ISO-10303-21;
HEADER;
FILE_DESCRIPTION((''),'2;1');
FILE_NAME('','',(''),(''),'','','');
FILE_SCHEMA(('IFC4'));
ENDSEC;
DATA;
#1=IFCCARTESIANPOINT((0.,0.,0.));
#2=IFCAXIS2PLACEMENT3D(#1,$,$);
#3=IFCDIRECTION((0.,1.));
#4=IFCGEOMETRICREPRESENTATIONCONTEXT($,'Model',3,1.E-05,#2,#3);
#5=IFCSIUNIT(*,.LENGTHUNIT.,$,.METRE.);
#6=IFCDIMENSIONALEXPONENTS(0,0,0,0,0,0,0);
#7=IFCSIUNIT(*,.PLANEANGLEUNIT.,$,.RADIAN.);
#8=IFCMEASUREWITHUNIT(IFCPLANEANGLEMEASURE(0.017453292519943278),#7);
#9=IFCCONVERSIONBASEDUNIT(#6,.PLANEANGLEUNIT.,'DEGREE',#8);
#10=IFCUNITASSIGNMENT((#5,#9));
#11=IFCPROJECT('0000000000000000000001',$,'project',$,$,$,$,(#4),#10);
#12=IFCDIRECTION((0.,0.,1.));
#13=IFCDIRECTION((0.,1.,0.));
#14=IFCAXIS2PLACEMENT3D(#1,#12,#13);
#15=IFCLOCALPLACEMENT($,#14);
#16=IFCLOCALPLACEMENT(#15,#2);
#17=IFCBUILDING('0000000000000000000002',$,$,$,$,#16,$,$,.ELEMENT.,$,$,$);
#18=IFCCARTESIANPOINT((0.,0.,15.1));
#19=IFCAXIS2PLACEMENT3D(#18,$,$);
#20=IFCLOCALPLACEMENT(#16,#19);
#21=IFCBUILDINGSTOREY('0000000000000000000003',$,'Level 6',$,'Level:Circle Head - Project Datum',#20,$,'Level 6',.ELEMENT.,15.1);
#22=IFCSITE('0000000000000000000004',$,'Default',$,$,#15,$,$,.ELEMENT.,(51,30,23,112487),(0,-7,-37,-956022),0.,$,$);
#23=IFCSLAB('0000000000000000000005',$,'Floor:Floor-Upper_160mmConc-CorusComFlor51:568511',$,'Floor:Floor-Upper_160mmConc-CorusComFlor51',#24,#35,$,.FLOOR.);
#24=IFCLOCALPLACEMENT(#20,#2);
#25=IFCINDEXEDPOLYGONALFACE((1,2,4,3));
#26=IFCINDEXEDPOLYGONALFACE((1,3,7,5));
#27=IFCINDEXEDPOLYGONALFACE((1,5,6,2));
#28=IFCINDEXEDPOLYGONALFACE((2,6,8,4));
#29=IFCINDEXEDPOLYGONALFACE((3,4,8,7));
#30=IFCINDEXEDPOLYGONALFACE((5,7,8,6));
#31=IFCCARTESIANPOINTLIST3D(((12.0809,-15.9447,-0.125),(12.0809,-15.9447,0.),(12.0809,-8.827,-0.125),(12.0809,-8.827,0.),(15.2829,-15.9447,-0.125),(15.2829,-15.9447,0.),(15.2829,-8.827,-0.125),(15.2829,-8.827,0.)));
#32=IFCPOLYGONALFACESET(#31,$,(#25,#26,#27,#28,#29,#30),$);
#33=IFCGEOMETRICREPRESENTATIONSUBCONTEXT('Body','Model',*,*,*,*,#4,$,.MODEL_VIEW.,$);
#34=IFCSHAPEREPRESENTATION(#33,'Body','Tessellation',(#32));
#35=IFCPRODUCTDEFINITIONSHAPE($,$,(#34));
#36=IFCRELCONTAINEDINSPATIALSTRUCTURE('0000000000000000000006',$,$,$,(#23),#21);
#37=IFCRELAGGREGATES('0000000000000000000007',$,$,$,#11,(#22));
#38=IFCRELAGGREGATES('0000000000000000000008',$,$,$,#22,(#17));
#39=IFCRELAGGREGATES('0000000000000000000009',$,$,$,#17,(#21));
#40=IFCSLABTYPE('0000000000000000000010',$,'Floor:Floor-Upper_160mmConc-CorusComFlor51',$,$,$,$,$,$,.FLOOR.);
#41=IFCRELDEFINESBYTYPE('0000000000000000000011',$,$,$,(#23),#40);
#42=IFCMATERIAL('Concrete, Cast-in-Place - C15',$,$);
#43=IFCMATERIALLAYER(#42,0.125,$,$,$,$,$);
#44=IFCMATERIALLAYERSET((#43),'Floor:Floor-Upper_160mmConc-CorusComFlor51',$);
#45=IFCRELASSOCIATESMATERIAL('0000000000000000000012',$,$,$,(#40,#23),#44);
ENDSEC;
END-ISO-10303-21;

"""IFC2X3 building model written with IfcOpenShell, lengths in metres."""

from ifc_helpers import new_model, entity, si_unit, converted_unit, direction, frame, frame_2d, origin, place, context, subcontext, project, spatial, rectangle, extrude, material, layer, layer_set, layer_usage, type_object, element, save


model = new_model("IFC2X3")

# Units and contexts
model_context = context("Model", 3, precision=1e-05, world=origin(), true_north=direction((0.0, 1.0)))
body_context = subcontext(model_context, "Body", "Model", "MODEL_VIEW")
ifc_project = project(units=[si_unit("LENGTHUNIT", "METRE"), converted_unit("PLANEANGLEUNIT", "DEGREE", entity("IfcPlaneAngleMeasure", 0.017453292519943278), si_unit("PLANEANGLEUNIT", "RADIAN"), dimensions=[0, 0, 0, 0, 0, 0, 0])], contexts=[model_context])

# Site, building, storey
site_placement = place(None, frame((0.0, 0.0, 0.0), z_axis=(0.0, 0.0, 1.0), x_axis=(0.0, 1.0, 0.0)))
site = spatial("IfcSite", under=ifc_project, at=site_placement, Name="Default", CompositionType="ELEMENT", RefLatitude=(51, 30, 23, 112487), RefLongitude=(0, -7, -37, -956022), RefElevation=0.0)
building_placement = place(site_placement, origin())
building = spatial("IfcBuilding", under=site, at=building_placement, CompositionType="ELEMENT")
storey_placement = place(building_placement, frame((0.0, 0.0, 15.1)))
storey = spatial("IfcBuildingStorey", under=building, at=storey_placement, Name="Level 6", ObjectType="Level:Circle Head - Project Datum", LongName="Level 6", CompositionType="ELEMENT", Elevation=15.1)

# Slab
ifc_material = material(Name="Concrete, Cast-in-Place - C15")
ifc_layer = layer(ifc_material, 0.125)
ifc_layer_set = layer_set([ifc_layer], Name="Floor:Floor-Upper_160mmConc-CorusComFlor51")
ifc_layer_usage = layer_usage(ifc_layer_set, "AXIS3", "POSITIVE", 0.0)
slab_type = type_object("IfcSlabType", Name="Floor:Floor-Upper_160mmConc-CorusComFlor51", PredefinedType="FLOOR", material=ifc_layer_set)
slab_placement = place(storey_placement, origin())
element("IfcSlab", 1, at=slab_placement, inside=storey, type_object=slab_type, material=ifc_layer_usage, Name="Floor:Floor-Upper_160mmConc-CorusComFlor51:568511", ObjectType="Floor:Floor-Upper_160mmConc-CorusComFlor51", PredefinedType="FLOOR", context=body_context, shape_type="SweptSolid", body=[
    extrude(rectangle(XDim=7.1177, YDim=3.2019, at=frame_2d((0.0, 0.0), x_axis=(1.0, 0.0))), frame((13.6819, -12.3859, 0.0), z_axis=(0.0, 0.0, -1.0), x_axis=(0.0, 1.0, 0.0)), (0.0, 0.0, 1.0), 0.125),
])

save(model, "model.ifc")
